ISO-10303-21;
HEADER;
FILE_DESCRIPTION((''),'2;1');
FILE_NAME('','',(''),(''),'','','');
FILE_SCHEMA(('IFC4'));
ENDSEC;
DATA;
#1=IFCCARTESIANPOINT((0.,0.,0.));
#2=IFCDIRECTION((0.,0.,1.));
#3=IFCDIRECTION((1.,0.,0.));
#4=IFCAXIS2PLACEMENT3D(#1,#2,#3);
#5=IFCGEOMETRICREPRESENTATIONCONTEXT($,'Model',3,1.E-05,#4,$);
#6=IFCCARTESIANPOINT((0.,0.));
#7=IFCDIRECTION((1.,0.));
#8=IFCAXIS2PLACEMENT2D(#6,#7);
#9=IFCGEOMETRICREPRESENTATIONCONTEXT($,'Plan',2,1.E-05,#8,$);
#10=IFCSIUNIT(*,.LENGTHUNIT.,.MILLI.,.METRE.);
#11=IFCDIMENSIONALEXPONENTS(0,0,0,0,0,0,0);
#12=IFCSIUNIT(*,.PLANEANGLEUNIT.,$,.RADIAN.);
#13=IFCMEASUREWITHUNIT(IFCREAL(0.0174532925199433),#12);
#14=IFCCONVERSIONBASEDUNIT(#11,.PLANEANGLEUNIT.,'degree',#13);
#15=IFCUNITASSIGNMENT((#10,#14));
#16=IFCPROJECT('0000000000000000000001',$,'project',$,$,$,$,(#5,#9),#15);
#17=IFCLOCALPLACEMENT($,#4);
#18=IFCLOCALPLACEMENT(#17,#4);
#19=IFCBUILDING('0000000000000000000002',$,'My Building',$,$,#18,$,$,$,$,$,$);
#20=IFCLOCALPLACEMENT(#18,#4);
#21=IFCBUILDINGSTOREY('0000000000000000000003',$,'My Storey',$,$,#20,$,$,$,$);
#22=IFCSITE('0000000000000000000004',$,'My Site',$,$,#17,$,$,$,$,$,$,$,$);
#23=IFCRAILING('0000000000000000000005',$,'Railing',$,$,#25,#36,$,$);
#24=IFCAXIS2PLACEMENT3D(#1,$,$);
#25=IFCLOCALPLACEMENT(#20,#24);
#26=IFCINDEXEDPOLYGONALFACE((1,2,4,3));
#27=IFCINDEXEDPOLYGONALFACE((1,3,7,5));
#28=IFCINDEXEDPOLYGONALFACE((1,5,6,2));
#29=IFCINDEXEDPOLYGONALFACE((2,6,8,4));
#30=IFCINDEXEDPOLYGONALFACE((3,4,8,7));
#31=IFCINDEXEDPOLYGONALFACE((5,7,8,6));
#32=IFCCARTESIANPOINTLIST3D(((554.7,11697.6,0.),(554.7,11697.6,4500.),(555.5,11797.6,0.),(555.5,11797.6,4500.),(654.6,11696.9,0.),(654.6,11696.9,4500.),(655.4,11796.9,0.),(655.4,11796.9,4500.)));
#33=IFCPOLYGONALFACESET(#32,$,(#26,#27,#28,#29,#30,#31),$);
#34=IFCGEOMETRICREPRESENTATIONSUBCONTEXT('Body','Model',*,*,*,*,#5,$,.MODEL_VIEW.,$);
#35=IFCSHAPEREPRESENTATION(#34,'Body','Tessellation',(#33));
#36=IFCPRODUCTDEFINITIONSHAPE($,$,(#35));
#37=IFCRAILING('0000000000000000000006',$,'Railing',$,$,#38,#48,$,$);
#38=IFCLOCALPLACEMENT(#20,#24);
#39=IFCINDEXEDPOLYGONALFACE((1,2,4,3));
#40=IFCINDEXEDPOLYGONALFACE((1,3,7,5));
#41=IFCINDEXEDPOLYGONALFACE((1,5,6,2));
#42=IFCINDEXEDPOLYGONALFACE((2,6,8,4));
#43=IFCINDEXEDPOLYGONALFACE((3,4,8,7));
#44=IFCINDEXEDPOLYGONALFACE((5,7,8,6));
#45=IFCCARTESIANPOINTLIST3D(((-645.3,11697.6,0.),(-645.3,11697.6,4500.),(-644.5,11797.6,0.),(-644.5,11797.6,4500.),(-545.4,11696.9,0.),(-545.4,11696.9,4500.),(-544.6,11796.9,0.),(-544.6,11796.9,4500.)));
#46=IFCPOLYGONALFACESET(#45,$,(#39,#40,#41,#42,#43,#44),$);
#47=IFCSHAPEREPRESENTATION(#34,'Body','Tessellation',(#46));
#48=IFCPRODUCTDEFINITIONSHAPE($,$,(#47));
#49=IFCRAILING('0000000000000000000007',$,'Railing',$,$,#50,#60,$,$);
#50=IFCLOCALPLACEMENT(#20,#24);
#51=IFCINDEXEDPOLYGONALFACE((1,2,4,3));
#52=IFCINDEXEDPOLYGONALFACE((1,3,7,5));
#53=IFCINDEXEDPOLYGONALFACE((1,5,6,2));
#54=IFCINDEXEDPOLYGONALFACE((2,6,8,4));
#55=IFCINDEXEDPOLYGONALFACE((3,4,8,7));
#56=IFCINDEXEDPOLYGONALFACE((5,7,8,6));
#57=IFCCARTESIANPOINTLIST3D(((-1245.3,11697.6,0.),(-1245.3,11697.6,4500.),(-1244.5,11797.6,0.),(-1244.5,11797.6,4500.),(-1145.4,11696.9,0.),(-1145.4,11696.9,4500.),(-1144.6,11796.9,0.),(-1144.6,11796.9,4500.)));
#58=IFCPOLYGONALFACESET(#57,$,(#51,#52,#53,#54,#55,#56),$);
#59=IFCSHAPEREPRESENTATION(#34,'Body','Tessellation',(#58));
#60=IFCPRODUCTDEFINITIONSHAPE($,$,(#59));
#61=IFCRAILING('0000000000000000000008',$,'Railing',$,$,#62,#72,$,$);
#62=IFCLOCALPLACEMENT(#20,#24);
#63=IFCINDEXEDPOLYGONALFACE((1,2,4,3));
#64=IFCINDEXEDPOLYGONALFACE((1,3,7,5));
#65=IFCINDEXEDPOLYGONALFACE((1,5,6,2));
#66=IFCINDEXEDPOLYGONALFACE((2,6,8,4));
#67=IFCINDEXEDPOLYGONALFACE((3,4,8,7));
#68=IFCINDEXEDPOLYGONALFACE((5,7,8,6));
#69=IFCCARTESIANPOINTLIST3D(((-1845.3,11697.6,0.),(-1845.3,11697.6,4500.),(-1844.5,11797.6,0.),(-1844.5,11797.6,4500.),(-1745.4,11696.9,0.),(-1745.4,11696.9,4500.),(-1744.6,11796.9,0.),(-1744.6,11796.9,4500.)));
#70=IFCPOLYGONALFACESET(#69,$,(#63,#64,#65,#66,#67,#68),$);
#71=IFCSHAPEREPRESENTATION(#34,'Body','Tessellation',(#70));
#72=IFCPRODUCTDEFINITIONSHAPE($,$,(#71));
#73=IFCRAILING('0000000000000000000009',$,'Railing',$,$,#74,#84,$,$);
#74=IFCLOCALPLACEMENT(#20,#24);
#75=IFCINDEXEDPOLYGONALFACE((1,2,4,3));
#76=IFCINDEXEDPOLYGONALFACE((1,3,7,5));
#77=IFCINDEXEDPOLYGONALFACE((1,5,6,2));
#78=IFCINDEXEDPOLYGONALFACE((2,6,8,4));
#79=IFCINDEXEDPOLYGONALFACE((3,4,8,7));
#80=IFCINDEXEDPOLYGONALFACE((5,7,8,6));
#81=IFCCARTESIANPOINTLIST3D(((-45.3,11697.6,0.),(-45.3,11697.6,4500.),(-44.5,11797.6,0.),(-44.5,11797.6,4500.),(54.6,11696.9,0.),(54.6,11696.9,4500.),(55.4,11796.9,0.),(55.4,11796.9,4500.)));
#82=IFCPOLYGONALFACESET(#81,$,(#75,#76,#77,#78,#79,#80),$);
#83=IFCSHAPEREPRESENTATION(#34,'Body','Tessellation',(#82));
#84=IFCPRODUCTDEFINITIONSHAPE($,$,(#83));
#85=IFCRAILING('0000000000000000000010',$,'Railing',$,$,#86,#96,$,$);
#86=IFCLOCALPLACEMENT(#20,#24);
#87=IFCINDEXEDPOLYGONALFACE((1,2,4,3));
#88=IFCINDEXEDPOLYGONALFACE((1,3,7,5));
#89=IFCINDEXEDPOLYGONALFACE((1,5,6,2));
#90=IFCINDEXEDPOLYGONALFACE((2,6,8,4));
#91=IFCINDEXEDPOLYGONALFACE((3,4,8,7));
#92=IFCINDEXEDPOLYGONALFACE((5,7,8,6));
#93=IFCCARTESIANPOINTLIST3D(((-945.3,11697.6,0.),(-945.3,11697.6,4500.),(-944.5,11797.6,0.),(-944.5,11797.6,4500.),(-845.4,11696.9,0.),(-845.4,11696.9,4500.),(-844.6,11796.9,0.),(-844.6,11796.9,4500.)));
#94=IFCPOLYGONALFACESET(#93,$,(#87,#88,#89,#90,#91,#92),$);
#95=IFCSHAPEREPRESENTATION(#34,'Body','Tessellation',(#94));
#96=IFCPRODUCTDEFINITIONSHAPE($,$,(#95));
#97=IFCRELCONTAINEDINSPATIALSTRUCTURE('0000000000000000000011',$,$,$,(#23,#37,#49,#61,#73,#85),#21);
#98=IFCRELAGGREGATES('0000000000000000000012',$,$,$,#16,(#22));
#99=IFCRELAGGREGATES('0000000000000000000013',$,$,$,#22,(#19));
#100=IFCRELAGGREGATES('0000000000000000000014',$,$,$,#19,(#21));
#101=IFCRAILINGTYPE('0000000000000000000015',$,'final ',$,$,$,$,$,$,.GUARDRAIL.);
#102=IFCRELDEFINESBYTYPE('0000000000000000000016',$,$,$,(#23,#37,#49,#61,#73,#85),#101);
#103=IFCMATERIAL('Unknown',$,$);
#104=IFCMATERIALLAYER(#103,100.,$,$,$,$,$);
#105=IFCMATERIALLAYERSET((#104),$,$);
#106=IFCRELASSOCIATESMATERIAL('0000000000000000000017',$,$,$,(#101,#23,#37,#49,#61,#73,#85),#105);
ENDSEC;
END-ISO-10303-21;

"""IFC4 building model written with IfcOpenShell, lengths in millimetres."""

from ifc_helpers import new_model, entity, si_unit, converted_unit, frame, origin_with_axes, origin_2d_with_axis, place, context, subcontext, project, spatial, line, indexed_curve, outline, extrude, material, layer, layer_set, layer_usage, type_object, element, save


model = new_model("IFC4")

# Units and contexts
model_context = context("Model", 3, precision=1e-05, world=origin_with_axes())
plan_context = context("Plan", 2, precision=1e-05, world=origin_2d_with_axis())
body_context = subcontext(model_context, "Body", "Model", "MODEL_VIEW")
ifc_project = project(units=[si_unit("LENGTHUNIT", "METRE", prefix="MILLI"), converted_unit("PLANEANGLEUNIT", "degree", entity("IfcReal", 0.0174532925199433), si_unit("PLANEANGLEUNIT", "RADIAN"), dimensions=[0, 0, 0, 0, 0, 0, 0])], contexts=[model_context, plan_context])

# Site, building, storey
site_placement = place(None, origin_with_axes())
site = spatial("IfcSite", under=ifc_project, at=site_placement, Name="My Site")
building_placement = place(site_placement, origin_with_axes())
building = spatial("IfcBuilding", under=site, at=building_placement, Name="My Building")
storey_placement = place(building_placement, origin_with_axes())
storey = spatial("IfcBuildingStorey", under=building, at=storey_placement, Name="My Storey")

# Shared definitions
ifc_material = material(Name="Unknown")

# Railings
ifc_layer_1 = layer(ifc_material, 100.0)
ifc_layer_set_1 = layer_set([ifc_layer_1])
railing_type = type_object("IfcRailingType", Name="final ", PredefinedType="GUARDRAIL", material=ifc_layer_set_1)
ifc_layer_usage_1 = layer_usage(ifc_layer_set_1, "AXIS2", "POSITIVE", 0.0)
railing_1_placement = place(storey_placement, frame((655.4, 11796.9, 0.0), z_axis=(0.0, 0.0, 1.0), x_axis=(-0.99997, 0.007689, 0.0)))
element("IfcRailing", 1, at=railing_1_placement, inside=storey, type_object=railing_type, material=ifc_layer_usage_1, Name="Railing", context=body_context, shape_type="SweptSolid", body=[
    extrude(outline(indexed_curve([(0.0, 0.0), (0.0, 100.0), (99.8, 100.0), (99.8, 0.0)], segments=[line(1, 2, 3, 4, 1)])), origin_with_axes(), (0.0, 0.0, 1.0), 4500.0),
])
ifc_layer_usage_2 = layer_usage(ifc_layer_set_1, "AXIS2", "POSITIVE", 0.0)
railing_2_placement = place(storey_placement, frame((-544.6, 11796.9, 0.0), z_axis=(0.0, 0.0, 1.0), x_axis=(-0.99997, 0.007689, 0.0)))
element("IfcRailing", 2, at=railing_2_placement, inside=storey, type_object=railing_type, material=ifc_layer_usage_2, Name="Railing", context=body_context, shape_type="SweptSolid", body=[
    extrude(outline(indexed_curve([(0.0, 0.0), (0.0, 100.0), (99.8, 100.0), (99.8, 0.0)], segments=[line(1, 2, 3, 4, 1)])), origin_with_axes(), (0.0, 0.0, 1.0), 4500.0),
])
ifc_layer_usage_3 = layer_usage(ifc_layer_set_1, "AXIS2", "POSITIVE", 0.0)
railing_3_placement = place(storey_placement, frame((-1144.6, 11796.9, 0.0), z_axis=(0.0, 0.0, 1.0), x_axis=(-0.99997, 0.007689, 0.0)))
element("IfcRailing", 3, at=railing_3_placement, inside=storey, type_object=railing_type, material=ifc_layer_usage_3, Name="Railing", context=body_context, shape_type="SweptSolid", body=[
    extrude(outline(indexed_curve([(0.0, 0.0), (0.0, 100.0), (99.8, 100.0), (99.8, 0.0)], segments=[line(1, 2, 3, 4, 1)])), origin_with_axes(), (0.0, 0.0, 1.0), 4500.0),
])
ifc_layer_usage_4 = layer_usage(ifc_layer_set_1, "AXIS2", "POSITIVE", 0.0)
railing_4_placement = place(storey_placement, frame((-1744.6, 11796.9, 0.0), z_axis=(0.0, 0.0, 1.0), x_axis=(-0.99997, 0.007689, 0.0)))
element("IfcRailing", 4, at=railing_4_placement, inside=storey, type_object=railing_type, material=ifc_layer_usage_4, Name="Railing", context=body_context, shape_type="SweptSolid", body=[
    extrude(outline(indexed_curve([(0.0, 0.0), (0.0, 100.0), (99.8, 100.0), (99.8, 0.0)], segments=[line(1, 2, 3, 4, 1)])), origin_with_axes(), (0.0, 0.0, 1.0), 4500.0),
])
ifc_layer_usage_5 = layer_usage(ifc_layer_set_1, "AXIS2", "POSITIVE", 0.0)
railing_5_placement = place(storey_placement, frame((55.4, 11796.9, 0.0), z_axis=(0.0, 0.0, 1.0), x_axis=(-0.99997, 0.007689, 0.0)))
element("IfcRailing", 5, at=railing_5_placement, inside=storey, type_object=railing_type, material=ifc_layer_usage_5, Name="Railing", context=body_context, shape_type="SweptSolid", body=[
    extrude(outline(indexed_curve([(0.0, 0.0), (0.0, 100.0), (99.8, 100.0), (99.8, 0.0)], segments=[line(1, 2, 3, 4, 1)])), origin_with_axes(), (0.0, 0.0, 1.0), 4500.0),
])
ifc_layer_usage_6 = layer_usage(ifc_layer_set_1, "AXIS2", "POSITIVE", 0.0)
railing_6_placement = place(storey_placement, frame((-844.6, 11796.9, 0.0), z_axis=(0.0, 0.0, 1.0), x_axis=(-0.99997, 0.007689, 0.0)))
element("IfcRailing", 6, at=railing_6_placement, inside=storey, type_object=railing_type, material=ifc_layer_usage_6, Name="Railing", context=body_context, shape_type="SweptSolid", body=[
    extrude(outline(indexed_curve([(0.0, 0.0), (0.0, 100.0), (99.8, 100.0), (99.8, 0.0)], segments=[line(1, 2, 3, 4, 1)])), origin_with_axes(), (0.0, 0.0, 1.0), 4500.0),
])

save(model, "model.ifc")
